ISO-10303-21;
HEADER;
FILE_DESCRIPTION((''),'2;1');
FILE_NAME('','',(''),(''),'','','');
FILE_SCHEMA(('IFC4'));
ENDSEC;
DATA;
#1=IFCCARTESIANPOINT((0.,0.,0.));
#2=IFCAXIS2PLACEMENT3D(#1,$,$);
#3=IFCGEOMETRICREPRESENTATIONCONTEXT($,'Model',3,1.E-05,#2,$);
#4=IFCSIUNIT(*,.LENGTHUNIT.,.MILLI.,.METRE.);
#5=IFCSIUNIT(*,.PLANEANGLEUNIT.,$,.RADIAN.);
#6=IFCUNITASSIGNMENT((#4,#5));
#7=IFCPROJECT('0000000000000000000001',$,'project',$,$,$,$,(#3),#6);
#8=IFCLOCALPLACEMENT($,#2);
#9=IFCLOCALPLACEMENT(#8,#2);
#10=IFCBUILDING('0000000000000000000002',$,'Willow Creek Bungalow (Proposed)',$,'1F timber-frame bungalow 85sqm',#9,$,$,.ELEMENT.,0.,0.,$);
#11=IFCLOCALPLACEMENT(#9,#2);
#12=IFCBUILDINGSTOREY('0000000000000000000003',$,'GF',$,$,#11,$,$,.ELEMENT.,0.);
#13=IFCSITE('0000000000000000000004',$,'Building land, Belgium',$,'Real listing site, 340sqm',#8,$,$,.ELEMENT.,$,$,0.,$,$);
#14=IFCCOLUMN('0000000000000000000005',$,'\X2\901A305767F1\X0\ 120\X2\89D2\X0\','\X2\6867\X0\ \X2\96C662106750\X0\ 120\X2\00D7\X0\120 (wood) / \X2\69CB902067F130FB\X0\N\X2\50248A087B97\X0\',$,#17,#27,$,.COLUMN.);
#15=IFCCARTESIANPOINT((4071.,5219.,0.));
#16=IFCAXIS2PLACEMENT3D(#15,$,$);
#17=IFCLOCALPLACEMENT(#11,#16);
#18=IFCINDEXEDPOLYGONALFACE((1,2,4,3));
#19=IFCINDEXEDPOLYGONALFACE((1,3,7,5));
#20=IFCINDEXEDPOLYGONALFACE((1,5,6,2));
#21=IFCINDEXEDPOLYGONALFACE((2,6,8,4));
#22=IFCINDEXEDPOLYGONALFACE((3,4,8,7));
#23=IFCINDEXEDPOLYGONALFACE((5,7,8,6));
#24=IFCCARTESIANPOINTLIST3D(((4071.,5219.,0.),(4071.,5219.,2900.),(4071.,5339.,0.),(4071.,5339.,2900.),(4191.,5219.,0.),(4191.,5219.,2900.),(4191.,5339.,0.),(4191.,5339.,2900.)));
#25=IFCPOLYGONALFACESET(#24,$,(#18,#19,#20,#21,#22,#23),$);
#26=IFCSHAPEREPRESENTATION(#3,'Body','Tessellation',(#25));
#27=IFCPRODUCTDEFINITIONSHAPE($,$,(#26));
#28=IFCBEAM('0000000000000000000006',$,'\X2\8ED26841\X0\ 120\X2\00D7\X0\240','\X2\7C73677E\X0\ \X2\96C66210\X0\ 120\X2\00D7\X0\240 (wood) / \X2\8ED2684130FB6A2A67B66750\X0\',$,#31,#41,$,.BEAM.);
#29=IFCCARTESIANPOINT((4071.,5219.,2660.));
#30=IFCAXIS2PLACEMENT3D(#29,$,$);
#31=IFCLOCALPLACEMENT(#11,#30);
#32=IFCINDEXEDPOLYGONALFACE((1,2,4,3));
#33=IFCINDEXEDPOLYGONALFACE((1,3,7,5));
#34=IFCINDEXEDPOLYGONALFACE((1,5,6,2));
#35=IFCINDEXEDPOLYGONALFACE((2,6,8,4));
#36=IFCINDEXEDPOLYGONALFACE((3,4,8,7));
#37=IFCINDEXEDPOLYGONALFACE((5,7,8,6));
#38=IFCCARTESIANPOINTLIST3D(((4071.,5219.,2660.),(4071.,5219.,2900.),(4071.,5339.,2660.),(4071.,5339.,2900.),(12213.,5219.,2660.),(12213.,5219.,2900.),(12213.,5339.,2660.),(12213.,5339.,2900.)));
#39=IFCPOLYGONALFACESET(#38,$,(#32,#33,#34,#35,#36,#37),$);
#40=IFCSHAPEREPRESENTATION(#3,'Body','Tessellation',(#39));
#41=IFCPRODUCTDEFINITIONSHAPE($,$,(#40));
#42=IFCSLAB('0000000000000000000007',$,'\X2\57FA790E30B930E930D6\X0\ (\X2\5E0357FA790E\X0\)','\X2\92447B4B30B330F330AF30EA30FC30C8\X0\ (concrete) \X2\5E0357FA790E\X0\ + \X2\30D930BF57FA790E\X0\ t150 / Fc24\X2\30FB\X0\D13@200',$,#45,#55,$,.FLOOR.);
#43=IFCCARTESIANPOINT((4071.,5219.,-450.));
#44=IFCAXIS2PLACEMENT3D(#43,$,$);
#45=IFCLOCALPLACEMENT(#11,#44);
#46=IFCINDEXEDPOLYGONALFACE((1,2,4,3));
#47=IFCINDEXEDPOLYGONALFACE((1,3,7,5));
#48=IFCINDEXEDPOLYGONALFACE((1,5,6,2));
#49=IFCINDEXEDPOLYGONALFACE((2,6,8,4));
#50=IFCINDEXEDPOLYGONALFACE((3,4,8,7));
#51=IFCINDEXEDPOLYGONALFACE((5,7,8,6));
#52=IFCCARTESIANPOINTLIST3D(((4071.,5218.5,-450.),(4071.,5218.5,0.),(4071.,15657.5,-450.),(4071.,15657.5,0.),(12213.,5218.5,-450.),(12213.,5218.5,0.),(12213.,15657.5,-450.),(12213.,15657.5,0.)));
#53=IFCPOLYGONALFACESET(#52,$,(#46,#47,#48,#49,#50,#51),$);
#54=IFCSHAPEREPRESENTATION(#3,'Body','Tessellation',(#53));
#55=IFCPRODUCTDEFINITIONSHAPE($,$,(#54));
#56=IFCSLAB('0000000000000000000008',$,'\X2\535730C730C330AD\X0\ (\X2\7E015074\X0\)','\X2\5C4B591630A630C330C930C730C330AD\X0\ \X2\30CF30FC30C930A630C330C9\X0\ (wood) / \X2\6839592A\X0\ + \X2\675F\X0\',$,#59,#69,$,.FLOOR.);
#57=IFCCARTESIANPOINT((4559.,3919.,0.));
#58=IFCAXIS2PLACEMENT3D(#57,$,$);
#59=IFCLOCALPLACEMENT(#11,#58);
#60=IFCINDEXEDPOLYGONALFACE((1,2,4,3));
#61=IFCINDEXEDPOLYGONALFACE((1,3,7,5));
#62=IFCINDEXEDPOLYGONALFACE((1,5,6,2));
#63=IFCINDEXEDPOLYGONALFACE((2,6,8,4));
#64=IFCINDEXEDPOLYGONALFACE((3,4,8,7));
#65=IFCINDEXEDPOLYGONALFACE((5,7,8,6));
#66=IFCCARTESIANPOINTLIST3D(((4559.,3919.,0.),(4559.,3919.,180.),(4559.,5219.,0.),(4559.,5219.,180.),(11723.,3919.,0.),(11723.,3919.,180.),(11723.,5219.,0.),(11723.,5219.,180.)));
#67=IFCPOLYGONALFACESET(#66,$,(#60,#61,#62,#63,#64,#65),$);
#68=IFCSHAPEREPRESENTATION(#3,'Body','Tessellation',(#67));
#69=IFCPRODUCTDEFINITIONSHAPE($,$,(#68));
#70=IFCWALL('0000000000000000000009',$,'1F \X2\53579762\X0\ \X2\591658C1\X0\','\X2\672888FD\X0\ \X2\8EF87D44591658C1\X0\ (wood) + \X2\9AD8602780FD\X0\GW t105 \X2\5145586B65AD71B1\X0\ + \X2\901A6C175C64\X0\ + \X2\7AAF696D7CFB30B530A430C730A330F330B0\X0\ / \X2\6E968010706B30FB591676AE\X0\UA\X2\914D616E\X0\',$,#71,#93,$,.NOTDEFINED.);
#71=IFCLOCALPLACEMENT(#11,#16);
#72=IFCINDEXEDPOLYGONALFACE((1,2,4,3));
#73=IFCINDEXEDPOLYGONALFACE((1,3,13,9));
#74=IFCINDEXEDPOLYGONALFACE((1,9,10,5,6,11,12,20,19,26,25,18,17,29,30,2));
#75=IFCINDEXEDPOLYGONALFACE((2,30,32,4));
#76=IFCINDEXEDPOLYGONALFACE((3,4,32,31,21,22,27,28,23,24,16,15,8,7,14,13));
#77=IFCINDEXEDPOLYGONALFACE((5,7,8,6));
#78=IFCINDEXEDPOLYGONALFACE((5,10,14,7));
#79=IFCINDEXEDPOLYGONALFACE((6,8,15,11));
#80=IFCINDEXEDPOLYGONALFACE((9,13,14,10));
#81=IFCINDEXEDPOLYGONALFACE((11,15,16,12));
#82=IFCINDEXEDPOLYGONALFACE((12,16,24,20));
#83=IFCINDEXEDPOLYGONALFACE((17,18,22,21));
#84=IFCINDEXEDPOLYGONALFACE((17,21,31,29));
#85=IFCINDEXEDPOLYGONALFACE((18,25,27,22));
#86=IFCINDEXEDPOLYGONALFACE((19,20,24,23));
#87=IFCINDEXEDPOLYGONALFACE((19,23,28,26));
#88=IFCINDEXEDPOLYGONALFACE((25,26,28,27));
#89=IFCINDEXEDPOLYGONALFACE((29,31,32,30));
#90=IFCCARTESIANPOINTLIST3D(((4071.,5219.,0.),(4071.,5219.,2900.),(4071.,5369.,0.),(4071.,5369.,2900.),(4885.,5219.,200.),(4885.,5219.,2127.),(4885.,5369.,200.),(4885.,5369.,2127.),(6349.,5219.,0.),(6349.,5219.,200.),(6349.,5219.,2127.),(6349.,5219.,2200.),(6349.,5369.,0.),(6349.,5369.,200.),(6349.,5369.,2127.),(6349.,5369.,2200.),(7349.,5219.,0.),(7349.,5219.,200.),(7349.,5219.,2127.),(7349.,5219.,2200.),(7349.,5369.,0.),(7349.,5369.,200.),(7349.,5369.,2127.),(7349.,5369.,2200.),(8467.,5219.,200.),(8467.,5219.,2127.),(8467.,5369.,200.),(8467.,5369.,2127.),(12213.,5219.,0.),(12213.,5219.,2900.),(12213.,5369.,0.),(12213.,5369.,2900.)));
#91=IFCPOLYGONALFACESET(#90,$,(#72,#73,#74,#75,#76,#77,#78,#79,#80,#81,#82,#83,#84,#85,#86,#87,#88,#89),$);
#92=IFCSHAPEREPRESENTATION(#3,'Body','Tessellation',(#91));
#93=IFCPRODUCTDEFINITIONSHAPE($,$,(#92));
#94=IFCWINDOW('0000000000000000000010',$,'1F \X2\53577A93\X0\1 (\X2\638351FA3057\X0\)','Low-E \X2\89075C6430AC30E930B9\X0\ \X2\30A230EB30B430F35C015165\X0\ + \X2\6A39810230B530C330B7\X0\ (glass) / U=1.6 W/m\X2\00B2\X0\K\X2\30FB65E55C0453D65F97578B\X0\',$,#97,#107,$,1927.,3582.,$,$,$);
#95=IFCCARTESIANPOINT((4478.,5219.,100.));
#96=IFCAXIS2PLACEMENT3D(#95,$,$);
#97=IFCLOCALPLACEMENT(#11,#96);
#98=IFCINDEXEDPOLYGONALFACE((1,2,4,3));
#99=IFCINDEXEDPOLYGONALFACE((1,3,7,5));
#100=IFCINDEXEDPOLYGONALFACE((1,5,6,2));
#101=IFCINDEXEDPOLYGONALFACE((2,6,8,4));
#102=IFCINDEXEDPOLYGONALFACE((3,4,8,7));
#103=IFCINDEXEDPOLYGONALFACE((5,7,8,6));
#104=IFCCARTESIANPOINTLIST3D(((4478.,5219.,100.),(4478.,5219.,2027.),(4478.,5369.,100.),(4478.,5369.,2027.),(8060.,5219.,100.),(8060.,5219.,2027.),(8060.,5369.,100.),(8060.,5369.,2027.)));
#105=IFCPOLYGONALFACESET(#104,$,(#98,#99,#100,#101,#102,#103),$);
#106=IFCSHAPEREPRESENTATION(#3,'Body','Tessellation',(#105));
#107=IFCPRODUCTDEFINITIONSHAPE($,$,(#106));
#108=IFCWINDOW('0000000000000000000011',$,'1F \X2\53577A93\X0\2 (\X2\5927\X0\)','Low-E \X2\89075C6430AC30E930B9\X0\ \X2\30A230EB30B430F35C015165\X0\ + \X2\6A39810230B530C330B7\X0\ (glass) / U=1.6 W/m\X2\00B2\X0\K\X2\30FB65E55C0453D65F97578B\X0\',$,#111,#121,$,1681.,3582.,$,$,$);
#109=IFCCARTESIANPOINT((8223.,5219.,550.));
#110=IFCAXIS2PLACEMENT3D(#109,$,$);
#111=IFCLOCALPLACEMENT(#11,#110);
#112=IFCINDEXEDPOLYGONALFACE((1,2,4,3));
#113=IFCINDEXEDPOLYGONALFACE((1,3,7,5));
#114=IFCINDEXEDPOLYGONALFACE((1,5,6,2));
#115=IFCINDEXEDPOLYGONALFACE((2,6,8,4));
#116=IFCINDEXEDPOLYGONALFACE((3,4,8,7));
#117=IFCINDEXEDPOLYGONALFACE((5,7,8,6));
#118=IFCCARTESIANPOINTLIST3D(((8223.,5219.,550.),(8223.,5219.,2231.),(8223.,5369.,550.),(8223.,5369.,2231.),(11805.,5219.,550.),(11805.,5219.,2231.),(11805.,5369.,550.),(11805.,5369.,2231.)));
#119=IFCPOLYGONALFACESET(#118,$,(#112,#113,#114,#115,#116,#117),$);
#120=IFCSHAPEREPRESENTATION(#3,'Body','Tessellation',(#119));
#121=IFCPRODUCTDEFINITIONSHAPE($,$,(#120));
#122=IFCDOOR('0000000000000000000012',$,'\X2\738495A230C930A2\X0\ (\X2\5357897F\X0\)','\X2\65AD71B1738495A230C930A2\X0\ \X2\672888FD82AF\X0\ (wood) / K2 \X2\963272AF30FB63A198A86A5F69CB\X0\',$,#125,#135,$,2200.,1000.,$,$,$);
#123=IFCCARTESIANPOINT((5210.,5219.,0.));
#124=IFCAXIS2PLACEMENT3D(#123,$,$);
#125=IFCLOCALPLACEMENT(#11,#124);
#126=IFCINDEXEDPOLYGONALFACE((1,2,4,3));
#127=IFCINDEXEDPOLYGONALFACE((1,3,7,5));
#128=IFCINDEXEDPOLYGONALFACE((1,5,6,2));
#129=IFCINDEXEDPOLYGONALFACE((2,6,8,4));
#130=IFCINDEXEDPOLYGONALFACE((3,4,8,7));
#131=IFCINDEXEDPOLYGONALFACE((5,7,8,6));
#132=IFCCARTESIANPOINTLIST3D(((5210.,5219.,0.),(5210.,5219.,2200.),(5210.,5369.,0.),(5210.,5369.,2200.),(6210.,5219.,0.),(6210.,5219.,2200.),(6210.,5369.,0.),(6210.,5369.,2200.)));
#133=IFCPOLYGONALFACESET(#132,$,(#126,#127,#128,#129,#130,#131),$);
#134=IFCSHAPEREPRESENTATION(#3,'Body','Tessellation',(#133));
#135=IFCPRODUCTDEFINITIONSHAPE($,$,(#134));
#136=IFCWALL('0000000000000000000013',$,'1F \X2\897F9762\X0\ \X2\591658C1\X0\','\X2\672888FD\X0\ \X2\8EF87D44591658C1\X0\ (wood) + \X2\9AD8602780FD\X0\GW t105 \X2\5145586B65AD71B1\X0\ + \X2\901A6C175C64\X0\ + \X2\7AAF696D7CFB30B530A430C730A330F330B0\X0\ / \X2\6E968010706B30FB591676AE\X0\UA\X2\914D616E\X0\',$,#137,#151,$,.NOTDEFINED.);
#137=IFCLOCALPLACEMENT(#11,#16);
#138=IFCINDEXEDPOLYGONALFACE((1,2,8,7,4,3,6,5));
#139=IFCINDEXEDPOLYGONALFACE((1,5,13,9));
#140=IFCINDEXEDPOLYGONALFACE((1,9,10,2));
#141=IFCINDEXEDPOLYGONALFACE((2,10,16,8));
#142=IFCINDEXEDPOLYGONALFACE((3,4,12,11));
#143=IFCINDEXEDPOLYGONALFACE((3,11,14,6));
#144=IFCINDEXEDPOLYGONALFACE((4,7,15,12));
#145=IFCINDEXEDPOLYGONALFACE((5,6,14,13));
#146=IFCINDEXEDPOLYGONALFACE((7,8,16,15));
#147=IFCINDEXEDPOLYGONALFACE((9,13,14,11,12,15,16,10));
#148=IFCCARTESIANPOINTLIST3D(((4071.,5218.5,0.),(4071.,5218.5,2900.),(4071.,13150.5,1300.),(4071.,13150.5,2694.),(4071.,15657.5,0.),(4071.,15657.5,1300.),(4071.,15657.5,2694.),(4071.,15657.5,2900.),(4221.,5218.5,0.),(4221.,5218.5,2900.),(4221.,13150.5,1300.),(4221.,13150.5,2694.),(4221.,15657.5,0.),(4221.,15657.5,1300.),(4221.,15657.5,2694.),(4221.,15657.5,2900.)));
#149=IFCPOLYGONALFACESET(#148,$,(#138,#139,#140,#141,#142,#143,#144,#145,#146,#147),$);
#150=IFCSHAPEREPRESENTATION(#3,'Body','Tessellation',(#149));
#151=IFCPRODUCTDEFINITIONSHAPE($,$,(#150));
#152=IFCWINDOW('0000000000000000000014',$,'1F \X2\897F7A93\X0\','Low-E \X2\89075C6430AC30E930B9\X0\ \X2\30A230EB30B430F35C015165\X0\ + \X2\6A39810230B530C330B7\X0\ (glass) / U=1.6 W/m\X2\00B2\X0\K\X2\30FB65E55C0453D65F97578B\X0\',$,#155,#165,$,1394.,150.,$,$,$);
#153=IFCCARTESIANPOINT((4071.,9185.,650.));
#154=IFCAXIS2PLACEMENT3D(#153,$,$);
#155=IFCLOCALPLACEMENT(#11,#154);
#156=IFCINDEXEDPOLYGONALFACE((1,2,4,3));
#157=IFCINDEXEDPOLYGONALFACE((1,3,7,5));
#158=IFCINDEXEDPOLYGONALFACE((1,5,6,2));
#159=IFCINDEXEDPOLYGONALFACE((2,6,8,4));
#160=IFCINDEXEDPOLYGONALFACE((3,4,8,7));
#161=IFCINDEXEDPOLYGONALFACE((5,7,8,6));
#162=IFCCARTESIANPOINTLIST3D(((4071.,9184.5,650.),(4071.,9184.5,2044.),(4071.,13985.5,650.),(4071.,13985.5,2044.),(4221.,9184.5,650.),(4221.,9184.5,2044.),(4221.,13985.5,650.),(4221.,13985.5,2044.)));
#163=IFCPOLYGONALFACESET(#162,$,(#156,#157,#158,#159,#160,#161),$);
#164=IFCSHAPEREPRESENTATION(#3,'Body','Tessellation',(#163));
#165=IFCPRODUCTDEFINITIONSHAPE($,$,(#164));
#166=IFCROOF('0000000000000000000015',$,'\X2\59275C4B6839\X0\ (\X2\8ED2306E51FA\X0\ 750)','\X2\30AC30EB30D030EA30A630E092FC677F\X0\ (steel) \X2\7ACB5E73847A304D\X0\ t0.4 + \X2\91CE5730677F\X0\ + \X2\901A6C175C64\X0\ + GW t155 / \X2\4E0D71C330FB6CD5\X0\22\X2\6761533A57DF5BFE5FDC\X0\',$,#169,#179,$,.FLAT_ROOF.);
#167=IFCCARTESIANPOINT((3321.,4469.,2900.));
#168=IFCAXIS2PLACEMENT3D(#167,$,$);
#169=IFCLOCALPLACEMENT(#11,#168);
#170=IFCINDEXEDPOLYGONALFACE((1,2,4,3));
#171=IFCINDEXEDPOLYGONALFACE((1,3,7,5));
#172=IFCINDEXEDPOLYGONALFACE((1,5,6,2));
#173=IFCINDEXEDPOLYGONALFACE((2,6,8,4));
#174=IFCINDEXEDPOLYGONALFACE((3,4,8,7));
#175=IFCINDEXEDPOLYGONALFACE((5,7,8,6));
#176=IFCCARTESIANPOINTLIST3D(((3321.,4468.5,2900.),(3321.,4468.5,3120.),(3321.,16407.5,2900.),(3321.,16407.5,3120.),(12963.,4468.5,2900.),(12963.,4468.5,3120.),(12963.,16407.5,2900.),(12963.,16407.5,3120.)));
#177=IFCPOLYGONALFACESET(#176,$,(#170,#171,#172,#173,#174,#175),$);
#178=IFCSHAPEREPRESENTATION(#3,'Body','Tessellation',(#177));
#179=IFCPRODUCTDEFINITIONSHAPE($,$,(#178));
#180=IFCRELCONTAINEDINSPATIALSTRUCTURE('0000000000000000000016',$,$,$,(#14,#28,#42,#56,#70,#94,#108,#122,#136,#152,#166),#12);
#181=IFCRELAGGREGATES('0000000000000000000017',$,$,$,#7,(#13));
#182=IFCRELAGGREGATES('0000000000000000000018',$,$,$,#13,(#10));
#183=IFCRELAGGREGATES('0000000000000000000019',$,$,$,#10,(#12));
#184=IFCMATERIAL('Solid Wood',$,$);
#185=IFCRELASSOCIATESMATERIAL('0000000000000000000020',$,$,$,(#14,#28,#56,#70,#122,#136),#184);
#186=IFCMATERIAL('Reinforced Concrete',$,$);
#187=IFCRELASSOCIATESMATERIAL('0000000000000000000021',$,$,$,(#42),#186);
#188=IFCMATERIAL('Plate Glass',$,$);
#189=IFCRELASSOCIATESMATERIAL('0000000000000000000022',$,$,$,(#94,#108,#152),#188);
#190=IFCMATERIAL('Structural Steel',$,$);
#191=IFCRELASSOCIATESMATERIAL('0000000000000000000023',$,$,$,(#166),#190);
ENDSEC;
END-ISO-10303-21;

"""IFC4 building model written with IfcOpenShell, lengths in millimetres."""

from ifc_helpers import new_model, si_unit, frame, frame_2d, origin, place, context, project, spatial, rectangle, extrude, material, element, fill, save


model = new_model("IFC4")

# Units and contexts
model_context = context("Model", 3, precision=1e-05, world=origin())
ifc_project = project(units=[si_unit("LENGTHUNIT", "METRE", prefix="MILLI"), si_unit("PLANEANGLEUNIT", "RADIAN")], contexts=[model_context])

# Site, building, storey
site_placement = place(None, origin())
site = spatial("IfcSite", under=ifc_project, at=site_placement, Name="Building land, Belgium", ObjectType="Real listing site, 340sqm", CompositionType="ELEMENT", RefElevation=0.0)
building_placement = place(site_placement, origin())
building = spatial("IfcBuilding", under=site, at=building_placement, Name="Willow Creek Bungalow (Proposed)", ObjectType="1F timber-frame bungalow 85sqm", CompositionType="ELEMENT", ElevationOfRefHeight=0.0, ElevationOfTerrain=0.0)
storey_placement = place(building_placement, origin())
storey = spatial("IfcBuildingStorey", under=building, at=storey_placement, Name="GF", CompositionType="ELEMENT", Elevation=0.0)

# Column
ifc_material_1 = material(Name="Solid Wood")
column_1_placement = place(storey_placement, frame((4071.0, 5219.0, 0.0)))
element("IfcColumn", 1, at=column_1_placement, inside=storey, material=ifc_material_1, Name="通し柱 120角", Description="桧 集成材 120×120 (wood) / 構造柱・N値計算", PredefinedType="COLUMN", context=model_context, shape_type="SweptSolid", body=[
    extrude(rectangle(XDim=120.0, YDim=120.0, at=frame_2d((60.0, 60.0))), frame((4071.0, 5219.0, 0.0)), (0.0, 0.0, 1.0), 2900.0),
])

# Beam
beam_1_placement = place(storey_placement, frame((4071.0, 5219.0, 2660.0)))
element("IfcBeam", 2, at=beam_1_placement, inside=storey, material=ifc_material_1, Name="軒桁 120×240", Description="米松 集成 120×240 (wood) / 軒桁・横架材", PredefinedType="BEAM", context=model_context, shape_type="SweptSolid", body=[
    extrude(rectangle(XDim=8142.0, YDim=120.0, at=frame_2d((4071.0, 60.0))), frame((4071.0, 5219.0, 2660.0)), (0.0, 0.0, 1.0), 240.0),
])

# Slabs
ifc_material_2 = material(Name="Reinforced Concrete")
slab_1_placement = place(storey_placement, frame((4071.0, 5219.0, -450.0)))
element("IfcSlab", 3, at=slab_1_placement, inside=storey, material=ifc_material_2, Name="基礎スラブ (布基礎)", Description="鉄筋コンクリート (concrete) 布基礎 + ベタ基礎 t150 / Fc24・D13@200", PredefinedType="FLOOR", context=model_context, shape_type="SweptSolid", body=[
    extrude(rectangle(XDim=8142.0, YDim=10439.0, at=frame_2d((4071.0, 5219.0))), frame((4071.0, 5219.0, -450.0)), (0.0, 0.0, 1.0), 450.0),
])
slab_2_placement = place(storey_placement, frame((4559.0, 3919.0, 0.0)))
element("IfcSlab", 4, at=slab_2_placement, inside=storey, material=ifc_material_1, Name="南デッキ (縁側)", Description="屋外ウッドデッキ ハードウッド (wood) / 根太 + 束", PredefinedType="FLOOR", context=model_context, shape_type="SweptSolid", body=[
    extrude(rectangle(XDim=7164.0, YDim=1300.0, at=frame_2d((3582.0, 650.0))), frame((4559.0, 3919.0, 0.0)), (0.0, 0.0, 1.0), 180.0),
])

# Wall, openings, windows, door
wall_1_placement = place(storey_placement, frame((4071.0, 5219.0, 0.0)))
wall_1 = element("IfcWall", 5, at=wall_1_placement, inside=storey, material=ifc_material_1, Name="1F 南面 外壁", Description="木製 軸組外壁 (wood) + 高性能GW t105 充填断熱 + 通気層 + 窯業系サイディング / 準耐火・外皮UA配慮", PredefinedType="NOTDEFINED", context=model_context, shape_type="SweptSolid", body=[
    extrude(rectangle(XDim=8142.0, YDim=150.0, at=frame_2d((4071.0, 75.0))), frame((4071.0, 5219.0, 0.0)), (0.0, 0.0, 1.0), 2900.0),
])
opening_1_placement = place(storey_placement, frame((4478.0, 5219.0, 100.0)))
opening_1 = element("IfcOpeningElement", 6, at=opening_1_placement, cuts=wall_1, PredefinedType="NOTDEFINED", context=model_context, shape_type="SweptSolid", body=[
    extrude(rectangle(XDim=3582.0, YDim=150.0, at=frame_2d((1791.0, 75.0))), frame((4478.0, 5219.0, 100.0)), (0.0, 0.0, 1.0), 1927.0),
])
opening_2_placement = place(storey_placement, frame((8223.0, 5219.0, 550.0)))
opening_2 = element("IfcOpeningElement", 7, at=opening_2_placement, cuts=wall_1, PredefinedType="NOTDEFINED", context=model_context, shape_type="SweptSolid", body=[
    extrude(rectangle(XDim=3582.0, YDim=150.0, at=frame_2d((1791.0, 75.0))), frame((8223.0, 5219.0, 550.0)), (0.0, 0.0, 1.0), 1681.0),
])
opening_3_placement = place(storey_placement, frame((5210.0, 5219.0, 0.0)))
opening_3 = element("IfcOpeningElement", 8, at=opening_3_placement, cuts=wall_1, PredefinedType="NOTDEFINED", context=model_context, shape_type="SweptSolid", body=[
    extrude(rectangle(XDim=1000.0, YDim=150.0, at=frame_2d((500.0, 75.0))), frame((5210.0, 5219.0, 0.0)), (0.0, 0.0, 1.0), 2200.0),
])
ifc_material_3 = material(Name="Plate Glass")
window_1_placement = place(storey_placement, frame((4478.0, 5219.0, 100.0)))
window_1 = element("IfcWindow", 9, at=window_1_placement, inside=storey, material=ifc_material_3, Name="1F 南窓1 (掃出し)", Description="Low-E 複層ガラス アルゴン封入 + 樹脂サッシ (glass) / U=1.6 W/m²K・日射取得型", OverallHeight=1927.0, OverallWidth=3582.0, context=model_context, shape_type="SweptSolid", body=[
    extrude(rectangle(XDim=3582.0, YDim=150.0, at=frame_2d((1791.0, 75.0))), frame((4478.0, 5219.0, 100.0)), (0.0, 0.0, 1.0), 1927.0),
])
fill(opening_1, window_1)
window_2_placement = place(storey_placement, frame((8223.0, 5219.0, 550.0)))
window_2 = element("IfcWindow", 10, at=window_2_placement, inside=storey, material=ifc_material_3, Name="1F 南窓2 (大)", Description="Low-E 複層ガラス アルゴン封入 + 樹脂サッシ (glass) / U=1.6 W/m²K・日射取得型", OverallHeight=1681.0, OverallWidth=3582.0, context=model_context, shape_type="SweptSolid", body=[
    extrude(rectangle(XDim=3582.0, YDim=150.0, at=frame_2d((1791.0, 75.0))), frame((8223.0, 5219.0, 550.0)), (0.0, 0.0, 1.0), 1681.0),
])
fill(opening_2, window_2)
door_placement = place(storey_placement, frame((5210.0, 5219.0, 0.0)))
door = element("IfcDoor", 11, at=door_placement, inside=storey, material=ifc_material_1, Name="玄関ドア (南西)", Description="断熱玄関ドア 木製芯 (wood) / K2 防犯・採風機構", OverallHeight=2200.0, OverallWidth=1000.0, context=model_context, shape_type="SweptSolid", body=[
    extrude(rectangle(XDim=1000.0, YDim=150.0, at=frame_2d((500.0, 75.0))), frame((5210.0, 5219.0, 0.0)), (0.0, 0.0, 1.0), 2200.0),
])
fill(opening_3, door)

# Wall, opening, window
wall_2_placement = place(storey_placement, frame((4071.0, 5219.0, 0.0)))
wall_2 = element("IfcWall", 12, at=wall_2_placement, inside=storey, material=ifc_material_1, Name="1F 西面 外壁", Description="木製 軸組外壁 (wood) + 高性能GW t105 充填断熱 + 通気層 + 窯業系サイディング / 準耐火・外皮UA配慮", PredefinedType="NOTDEFINED", context=model_context, shape_type="SweptSolid", body=[
    extrude(rectangle(XDim=150.0, YDim=10439.0, at=frame_2d((75.0, 5219.0))), frame((4071.0, 5219.0, 0.0)), (0.0, 0.0, 1.0), 2900.0),
])
opening_4_placement = place(storey_placement, frame((4071.0, 9185.0, 650.0)))
opening_4 = element("IfcOpeningElement", 13, at=opening_4_placement, cuts=wall_2, PredefinedType="NOTDEFINED", context=model_context, shape_type="SweptSolid", body=[
    extrude(rectangle(XDim=150.0, YDim=4801.0, at=frame_2d((75.0, 2400.0))), frame((4071.0, 9185.0, 650.0)), (0.0, 0.0, 1.0), 1394.0),
])
window_3_placement = place(storey_placement, frame((4071.0, 9185.0, 650.0)))
window_3 = element("IfcWindow", 14, at=window_3_placement, inside=storey, material=ifc_material_3, Name="1F 西窓", Description="Low-E 複層ガラス アルゴン封入 + 樹脂サッシ (glass) / U=1.6 W/m²K・日射取得型", OverallHeight=1394.0, OverallWidth=150.0, context=model_context, shape_type="SweptSolid", body=[
    extrude(rectangle(XDim=150.0, YDim=4801.0, at=frame_2d((75.0, 2400.0))), frame((4071.0, 9185.0, 650.0)), (0.0, 0.0, 1.0), 1394.0),
])
fill(opening_4, window_3)

# Roof
ifc_material_4 = material(Name="Structural Steel")
roof_placement = place(storey_placement, frame((3321.0, 4469.0, 2900.0)))
element("IfcRoof", 15, at=roof_placement, inside=storey, material=ifc_material_4, Name="大屋根 (軒の出 750)", Description="ガルバリウム鋼板 (steel) 立平葺き t0.4 + 野地板 + 通気層 + GW t155 / 不燃・法22条区域対応", PredefinedType="FLAT_ROOF", context=model_context, shape_type="SweptSolid", body=[
    extrude(rectangle(XDim=9642.0, YDim=11939.0, at=frame_2d((4821.0, 5969.0))), frame((3321.0, 4469.0, 2900.0)), (0.0, 0.0, 1.0), 220.0),
])

save(model, "model.ifc")
